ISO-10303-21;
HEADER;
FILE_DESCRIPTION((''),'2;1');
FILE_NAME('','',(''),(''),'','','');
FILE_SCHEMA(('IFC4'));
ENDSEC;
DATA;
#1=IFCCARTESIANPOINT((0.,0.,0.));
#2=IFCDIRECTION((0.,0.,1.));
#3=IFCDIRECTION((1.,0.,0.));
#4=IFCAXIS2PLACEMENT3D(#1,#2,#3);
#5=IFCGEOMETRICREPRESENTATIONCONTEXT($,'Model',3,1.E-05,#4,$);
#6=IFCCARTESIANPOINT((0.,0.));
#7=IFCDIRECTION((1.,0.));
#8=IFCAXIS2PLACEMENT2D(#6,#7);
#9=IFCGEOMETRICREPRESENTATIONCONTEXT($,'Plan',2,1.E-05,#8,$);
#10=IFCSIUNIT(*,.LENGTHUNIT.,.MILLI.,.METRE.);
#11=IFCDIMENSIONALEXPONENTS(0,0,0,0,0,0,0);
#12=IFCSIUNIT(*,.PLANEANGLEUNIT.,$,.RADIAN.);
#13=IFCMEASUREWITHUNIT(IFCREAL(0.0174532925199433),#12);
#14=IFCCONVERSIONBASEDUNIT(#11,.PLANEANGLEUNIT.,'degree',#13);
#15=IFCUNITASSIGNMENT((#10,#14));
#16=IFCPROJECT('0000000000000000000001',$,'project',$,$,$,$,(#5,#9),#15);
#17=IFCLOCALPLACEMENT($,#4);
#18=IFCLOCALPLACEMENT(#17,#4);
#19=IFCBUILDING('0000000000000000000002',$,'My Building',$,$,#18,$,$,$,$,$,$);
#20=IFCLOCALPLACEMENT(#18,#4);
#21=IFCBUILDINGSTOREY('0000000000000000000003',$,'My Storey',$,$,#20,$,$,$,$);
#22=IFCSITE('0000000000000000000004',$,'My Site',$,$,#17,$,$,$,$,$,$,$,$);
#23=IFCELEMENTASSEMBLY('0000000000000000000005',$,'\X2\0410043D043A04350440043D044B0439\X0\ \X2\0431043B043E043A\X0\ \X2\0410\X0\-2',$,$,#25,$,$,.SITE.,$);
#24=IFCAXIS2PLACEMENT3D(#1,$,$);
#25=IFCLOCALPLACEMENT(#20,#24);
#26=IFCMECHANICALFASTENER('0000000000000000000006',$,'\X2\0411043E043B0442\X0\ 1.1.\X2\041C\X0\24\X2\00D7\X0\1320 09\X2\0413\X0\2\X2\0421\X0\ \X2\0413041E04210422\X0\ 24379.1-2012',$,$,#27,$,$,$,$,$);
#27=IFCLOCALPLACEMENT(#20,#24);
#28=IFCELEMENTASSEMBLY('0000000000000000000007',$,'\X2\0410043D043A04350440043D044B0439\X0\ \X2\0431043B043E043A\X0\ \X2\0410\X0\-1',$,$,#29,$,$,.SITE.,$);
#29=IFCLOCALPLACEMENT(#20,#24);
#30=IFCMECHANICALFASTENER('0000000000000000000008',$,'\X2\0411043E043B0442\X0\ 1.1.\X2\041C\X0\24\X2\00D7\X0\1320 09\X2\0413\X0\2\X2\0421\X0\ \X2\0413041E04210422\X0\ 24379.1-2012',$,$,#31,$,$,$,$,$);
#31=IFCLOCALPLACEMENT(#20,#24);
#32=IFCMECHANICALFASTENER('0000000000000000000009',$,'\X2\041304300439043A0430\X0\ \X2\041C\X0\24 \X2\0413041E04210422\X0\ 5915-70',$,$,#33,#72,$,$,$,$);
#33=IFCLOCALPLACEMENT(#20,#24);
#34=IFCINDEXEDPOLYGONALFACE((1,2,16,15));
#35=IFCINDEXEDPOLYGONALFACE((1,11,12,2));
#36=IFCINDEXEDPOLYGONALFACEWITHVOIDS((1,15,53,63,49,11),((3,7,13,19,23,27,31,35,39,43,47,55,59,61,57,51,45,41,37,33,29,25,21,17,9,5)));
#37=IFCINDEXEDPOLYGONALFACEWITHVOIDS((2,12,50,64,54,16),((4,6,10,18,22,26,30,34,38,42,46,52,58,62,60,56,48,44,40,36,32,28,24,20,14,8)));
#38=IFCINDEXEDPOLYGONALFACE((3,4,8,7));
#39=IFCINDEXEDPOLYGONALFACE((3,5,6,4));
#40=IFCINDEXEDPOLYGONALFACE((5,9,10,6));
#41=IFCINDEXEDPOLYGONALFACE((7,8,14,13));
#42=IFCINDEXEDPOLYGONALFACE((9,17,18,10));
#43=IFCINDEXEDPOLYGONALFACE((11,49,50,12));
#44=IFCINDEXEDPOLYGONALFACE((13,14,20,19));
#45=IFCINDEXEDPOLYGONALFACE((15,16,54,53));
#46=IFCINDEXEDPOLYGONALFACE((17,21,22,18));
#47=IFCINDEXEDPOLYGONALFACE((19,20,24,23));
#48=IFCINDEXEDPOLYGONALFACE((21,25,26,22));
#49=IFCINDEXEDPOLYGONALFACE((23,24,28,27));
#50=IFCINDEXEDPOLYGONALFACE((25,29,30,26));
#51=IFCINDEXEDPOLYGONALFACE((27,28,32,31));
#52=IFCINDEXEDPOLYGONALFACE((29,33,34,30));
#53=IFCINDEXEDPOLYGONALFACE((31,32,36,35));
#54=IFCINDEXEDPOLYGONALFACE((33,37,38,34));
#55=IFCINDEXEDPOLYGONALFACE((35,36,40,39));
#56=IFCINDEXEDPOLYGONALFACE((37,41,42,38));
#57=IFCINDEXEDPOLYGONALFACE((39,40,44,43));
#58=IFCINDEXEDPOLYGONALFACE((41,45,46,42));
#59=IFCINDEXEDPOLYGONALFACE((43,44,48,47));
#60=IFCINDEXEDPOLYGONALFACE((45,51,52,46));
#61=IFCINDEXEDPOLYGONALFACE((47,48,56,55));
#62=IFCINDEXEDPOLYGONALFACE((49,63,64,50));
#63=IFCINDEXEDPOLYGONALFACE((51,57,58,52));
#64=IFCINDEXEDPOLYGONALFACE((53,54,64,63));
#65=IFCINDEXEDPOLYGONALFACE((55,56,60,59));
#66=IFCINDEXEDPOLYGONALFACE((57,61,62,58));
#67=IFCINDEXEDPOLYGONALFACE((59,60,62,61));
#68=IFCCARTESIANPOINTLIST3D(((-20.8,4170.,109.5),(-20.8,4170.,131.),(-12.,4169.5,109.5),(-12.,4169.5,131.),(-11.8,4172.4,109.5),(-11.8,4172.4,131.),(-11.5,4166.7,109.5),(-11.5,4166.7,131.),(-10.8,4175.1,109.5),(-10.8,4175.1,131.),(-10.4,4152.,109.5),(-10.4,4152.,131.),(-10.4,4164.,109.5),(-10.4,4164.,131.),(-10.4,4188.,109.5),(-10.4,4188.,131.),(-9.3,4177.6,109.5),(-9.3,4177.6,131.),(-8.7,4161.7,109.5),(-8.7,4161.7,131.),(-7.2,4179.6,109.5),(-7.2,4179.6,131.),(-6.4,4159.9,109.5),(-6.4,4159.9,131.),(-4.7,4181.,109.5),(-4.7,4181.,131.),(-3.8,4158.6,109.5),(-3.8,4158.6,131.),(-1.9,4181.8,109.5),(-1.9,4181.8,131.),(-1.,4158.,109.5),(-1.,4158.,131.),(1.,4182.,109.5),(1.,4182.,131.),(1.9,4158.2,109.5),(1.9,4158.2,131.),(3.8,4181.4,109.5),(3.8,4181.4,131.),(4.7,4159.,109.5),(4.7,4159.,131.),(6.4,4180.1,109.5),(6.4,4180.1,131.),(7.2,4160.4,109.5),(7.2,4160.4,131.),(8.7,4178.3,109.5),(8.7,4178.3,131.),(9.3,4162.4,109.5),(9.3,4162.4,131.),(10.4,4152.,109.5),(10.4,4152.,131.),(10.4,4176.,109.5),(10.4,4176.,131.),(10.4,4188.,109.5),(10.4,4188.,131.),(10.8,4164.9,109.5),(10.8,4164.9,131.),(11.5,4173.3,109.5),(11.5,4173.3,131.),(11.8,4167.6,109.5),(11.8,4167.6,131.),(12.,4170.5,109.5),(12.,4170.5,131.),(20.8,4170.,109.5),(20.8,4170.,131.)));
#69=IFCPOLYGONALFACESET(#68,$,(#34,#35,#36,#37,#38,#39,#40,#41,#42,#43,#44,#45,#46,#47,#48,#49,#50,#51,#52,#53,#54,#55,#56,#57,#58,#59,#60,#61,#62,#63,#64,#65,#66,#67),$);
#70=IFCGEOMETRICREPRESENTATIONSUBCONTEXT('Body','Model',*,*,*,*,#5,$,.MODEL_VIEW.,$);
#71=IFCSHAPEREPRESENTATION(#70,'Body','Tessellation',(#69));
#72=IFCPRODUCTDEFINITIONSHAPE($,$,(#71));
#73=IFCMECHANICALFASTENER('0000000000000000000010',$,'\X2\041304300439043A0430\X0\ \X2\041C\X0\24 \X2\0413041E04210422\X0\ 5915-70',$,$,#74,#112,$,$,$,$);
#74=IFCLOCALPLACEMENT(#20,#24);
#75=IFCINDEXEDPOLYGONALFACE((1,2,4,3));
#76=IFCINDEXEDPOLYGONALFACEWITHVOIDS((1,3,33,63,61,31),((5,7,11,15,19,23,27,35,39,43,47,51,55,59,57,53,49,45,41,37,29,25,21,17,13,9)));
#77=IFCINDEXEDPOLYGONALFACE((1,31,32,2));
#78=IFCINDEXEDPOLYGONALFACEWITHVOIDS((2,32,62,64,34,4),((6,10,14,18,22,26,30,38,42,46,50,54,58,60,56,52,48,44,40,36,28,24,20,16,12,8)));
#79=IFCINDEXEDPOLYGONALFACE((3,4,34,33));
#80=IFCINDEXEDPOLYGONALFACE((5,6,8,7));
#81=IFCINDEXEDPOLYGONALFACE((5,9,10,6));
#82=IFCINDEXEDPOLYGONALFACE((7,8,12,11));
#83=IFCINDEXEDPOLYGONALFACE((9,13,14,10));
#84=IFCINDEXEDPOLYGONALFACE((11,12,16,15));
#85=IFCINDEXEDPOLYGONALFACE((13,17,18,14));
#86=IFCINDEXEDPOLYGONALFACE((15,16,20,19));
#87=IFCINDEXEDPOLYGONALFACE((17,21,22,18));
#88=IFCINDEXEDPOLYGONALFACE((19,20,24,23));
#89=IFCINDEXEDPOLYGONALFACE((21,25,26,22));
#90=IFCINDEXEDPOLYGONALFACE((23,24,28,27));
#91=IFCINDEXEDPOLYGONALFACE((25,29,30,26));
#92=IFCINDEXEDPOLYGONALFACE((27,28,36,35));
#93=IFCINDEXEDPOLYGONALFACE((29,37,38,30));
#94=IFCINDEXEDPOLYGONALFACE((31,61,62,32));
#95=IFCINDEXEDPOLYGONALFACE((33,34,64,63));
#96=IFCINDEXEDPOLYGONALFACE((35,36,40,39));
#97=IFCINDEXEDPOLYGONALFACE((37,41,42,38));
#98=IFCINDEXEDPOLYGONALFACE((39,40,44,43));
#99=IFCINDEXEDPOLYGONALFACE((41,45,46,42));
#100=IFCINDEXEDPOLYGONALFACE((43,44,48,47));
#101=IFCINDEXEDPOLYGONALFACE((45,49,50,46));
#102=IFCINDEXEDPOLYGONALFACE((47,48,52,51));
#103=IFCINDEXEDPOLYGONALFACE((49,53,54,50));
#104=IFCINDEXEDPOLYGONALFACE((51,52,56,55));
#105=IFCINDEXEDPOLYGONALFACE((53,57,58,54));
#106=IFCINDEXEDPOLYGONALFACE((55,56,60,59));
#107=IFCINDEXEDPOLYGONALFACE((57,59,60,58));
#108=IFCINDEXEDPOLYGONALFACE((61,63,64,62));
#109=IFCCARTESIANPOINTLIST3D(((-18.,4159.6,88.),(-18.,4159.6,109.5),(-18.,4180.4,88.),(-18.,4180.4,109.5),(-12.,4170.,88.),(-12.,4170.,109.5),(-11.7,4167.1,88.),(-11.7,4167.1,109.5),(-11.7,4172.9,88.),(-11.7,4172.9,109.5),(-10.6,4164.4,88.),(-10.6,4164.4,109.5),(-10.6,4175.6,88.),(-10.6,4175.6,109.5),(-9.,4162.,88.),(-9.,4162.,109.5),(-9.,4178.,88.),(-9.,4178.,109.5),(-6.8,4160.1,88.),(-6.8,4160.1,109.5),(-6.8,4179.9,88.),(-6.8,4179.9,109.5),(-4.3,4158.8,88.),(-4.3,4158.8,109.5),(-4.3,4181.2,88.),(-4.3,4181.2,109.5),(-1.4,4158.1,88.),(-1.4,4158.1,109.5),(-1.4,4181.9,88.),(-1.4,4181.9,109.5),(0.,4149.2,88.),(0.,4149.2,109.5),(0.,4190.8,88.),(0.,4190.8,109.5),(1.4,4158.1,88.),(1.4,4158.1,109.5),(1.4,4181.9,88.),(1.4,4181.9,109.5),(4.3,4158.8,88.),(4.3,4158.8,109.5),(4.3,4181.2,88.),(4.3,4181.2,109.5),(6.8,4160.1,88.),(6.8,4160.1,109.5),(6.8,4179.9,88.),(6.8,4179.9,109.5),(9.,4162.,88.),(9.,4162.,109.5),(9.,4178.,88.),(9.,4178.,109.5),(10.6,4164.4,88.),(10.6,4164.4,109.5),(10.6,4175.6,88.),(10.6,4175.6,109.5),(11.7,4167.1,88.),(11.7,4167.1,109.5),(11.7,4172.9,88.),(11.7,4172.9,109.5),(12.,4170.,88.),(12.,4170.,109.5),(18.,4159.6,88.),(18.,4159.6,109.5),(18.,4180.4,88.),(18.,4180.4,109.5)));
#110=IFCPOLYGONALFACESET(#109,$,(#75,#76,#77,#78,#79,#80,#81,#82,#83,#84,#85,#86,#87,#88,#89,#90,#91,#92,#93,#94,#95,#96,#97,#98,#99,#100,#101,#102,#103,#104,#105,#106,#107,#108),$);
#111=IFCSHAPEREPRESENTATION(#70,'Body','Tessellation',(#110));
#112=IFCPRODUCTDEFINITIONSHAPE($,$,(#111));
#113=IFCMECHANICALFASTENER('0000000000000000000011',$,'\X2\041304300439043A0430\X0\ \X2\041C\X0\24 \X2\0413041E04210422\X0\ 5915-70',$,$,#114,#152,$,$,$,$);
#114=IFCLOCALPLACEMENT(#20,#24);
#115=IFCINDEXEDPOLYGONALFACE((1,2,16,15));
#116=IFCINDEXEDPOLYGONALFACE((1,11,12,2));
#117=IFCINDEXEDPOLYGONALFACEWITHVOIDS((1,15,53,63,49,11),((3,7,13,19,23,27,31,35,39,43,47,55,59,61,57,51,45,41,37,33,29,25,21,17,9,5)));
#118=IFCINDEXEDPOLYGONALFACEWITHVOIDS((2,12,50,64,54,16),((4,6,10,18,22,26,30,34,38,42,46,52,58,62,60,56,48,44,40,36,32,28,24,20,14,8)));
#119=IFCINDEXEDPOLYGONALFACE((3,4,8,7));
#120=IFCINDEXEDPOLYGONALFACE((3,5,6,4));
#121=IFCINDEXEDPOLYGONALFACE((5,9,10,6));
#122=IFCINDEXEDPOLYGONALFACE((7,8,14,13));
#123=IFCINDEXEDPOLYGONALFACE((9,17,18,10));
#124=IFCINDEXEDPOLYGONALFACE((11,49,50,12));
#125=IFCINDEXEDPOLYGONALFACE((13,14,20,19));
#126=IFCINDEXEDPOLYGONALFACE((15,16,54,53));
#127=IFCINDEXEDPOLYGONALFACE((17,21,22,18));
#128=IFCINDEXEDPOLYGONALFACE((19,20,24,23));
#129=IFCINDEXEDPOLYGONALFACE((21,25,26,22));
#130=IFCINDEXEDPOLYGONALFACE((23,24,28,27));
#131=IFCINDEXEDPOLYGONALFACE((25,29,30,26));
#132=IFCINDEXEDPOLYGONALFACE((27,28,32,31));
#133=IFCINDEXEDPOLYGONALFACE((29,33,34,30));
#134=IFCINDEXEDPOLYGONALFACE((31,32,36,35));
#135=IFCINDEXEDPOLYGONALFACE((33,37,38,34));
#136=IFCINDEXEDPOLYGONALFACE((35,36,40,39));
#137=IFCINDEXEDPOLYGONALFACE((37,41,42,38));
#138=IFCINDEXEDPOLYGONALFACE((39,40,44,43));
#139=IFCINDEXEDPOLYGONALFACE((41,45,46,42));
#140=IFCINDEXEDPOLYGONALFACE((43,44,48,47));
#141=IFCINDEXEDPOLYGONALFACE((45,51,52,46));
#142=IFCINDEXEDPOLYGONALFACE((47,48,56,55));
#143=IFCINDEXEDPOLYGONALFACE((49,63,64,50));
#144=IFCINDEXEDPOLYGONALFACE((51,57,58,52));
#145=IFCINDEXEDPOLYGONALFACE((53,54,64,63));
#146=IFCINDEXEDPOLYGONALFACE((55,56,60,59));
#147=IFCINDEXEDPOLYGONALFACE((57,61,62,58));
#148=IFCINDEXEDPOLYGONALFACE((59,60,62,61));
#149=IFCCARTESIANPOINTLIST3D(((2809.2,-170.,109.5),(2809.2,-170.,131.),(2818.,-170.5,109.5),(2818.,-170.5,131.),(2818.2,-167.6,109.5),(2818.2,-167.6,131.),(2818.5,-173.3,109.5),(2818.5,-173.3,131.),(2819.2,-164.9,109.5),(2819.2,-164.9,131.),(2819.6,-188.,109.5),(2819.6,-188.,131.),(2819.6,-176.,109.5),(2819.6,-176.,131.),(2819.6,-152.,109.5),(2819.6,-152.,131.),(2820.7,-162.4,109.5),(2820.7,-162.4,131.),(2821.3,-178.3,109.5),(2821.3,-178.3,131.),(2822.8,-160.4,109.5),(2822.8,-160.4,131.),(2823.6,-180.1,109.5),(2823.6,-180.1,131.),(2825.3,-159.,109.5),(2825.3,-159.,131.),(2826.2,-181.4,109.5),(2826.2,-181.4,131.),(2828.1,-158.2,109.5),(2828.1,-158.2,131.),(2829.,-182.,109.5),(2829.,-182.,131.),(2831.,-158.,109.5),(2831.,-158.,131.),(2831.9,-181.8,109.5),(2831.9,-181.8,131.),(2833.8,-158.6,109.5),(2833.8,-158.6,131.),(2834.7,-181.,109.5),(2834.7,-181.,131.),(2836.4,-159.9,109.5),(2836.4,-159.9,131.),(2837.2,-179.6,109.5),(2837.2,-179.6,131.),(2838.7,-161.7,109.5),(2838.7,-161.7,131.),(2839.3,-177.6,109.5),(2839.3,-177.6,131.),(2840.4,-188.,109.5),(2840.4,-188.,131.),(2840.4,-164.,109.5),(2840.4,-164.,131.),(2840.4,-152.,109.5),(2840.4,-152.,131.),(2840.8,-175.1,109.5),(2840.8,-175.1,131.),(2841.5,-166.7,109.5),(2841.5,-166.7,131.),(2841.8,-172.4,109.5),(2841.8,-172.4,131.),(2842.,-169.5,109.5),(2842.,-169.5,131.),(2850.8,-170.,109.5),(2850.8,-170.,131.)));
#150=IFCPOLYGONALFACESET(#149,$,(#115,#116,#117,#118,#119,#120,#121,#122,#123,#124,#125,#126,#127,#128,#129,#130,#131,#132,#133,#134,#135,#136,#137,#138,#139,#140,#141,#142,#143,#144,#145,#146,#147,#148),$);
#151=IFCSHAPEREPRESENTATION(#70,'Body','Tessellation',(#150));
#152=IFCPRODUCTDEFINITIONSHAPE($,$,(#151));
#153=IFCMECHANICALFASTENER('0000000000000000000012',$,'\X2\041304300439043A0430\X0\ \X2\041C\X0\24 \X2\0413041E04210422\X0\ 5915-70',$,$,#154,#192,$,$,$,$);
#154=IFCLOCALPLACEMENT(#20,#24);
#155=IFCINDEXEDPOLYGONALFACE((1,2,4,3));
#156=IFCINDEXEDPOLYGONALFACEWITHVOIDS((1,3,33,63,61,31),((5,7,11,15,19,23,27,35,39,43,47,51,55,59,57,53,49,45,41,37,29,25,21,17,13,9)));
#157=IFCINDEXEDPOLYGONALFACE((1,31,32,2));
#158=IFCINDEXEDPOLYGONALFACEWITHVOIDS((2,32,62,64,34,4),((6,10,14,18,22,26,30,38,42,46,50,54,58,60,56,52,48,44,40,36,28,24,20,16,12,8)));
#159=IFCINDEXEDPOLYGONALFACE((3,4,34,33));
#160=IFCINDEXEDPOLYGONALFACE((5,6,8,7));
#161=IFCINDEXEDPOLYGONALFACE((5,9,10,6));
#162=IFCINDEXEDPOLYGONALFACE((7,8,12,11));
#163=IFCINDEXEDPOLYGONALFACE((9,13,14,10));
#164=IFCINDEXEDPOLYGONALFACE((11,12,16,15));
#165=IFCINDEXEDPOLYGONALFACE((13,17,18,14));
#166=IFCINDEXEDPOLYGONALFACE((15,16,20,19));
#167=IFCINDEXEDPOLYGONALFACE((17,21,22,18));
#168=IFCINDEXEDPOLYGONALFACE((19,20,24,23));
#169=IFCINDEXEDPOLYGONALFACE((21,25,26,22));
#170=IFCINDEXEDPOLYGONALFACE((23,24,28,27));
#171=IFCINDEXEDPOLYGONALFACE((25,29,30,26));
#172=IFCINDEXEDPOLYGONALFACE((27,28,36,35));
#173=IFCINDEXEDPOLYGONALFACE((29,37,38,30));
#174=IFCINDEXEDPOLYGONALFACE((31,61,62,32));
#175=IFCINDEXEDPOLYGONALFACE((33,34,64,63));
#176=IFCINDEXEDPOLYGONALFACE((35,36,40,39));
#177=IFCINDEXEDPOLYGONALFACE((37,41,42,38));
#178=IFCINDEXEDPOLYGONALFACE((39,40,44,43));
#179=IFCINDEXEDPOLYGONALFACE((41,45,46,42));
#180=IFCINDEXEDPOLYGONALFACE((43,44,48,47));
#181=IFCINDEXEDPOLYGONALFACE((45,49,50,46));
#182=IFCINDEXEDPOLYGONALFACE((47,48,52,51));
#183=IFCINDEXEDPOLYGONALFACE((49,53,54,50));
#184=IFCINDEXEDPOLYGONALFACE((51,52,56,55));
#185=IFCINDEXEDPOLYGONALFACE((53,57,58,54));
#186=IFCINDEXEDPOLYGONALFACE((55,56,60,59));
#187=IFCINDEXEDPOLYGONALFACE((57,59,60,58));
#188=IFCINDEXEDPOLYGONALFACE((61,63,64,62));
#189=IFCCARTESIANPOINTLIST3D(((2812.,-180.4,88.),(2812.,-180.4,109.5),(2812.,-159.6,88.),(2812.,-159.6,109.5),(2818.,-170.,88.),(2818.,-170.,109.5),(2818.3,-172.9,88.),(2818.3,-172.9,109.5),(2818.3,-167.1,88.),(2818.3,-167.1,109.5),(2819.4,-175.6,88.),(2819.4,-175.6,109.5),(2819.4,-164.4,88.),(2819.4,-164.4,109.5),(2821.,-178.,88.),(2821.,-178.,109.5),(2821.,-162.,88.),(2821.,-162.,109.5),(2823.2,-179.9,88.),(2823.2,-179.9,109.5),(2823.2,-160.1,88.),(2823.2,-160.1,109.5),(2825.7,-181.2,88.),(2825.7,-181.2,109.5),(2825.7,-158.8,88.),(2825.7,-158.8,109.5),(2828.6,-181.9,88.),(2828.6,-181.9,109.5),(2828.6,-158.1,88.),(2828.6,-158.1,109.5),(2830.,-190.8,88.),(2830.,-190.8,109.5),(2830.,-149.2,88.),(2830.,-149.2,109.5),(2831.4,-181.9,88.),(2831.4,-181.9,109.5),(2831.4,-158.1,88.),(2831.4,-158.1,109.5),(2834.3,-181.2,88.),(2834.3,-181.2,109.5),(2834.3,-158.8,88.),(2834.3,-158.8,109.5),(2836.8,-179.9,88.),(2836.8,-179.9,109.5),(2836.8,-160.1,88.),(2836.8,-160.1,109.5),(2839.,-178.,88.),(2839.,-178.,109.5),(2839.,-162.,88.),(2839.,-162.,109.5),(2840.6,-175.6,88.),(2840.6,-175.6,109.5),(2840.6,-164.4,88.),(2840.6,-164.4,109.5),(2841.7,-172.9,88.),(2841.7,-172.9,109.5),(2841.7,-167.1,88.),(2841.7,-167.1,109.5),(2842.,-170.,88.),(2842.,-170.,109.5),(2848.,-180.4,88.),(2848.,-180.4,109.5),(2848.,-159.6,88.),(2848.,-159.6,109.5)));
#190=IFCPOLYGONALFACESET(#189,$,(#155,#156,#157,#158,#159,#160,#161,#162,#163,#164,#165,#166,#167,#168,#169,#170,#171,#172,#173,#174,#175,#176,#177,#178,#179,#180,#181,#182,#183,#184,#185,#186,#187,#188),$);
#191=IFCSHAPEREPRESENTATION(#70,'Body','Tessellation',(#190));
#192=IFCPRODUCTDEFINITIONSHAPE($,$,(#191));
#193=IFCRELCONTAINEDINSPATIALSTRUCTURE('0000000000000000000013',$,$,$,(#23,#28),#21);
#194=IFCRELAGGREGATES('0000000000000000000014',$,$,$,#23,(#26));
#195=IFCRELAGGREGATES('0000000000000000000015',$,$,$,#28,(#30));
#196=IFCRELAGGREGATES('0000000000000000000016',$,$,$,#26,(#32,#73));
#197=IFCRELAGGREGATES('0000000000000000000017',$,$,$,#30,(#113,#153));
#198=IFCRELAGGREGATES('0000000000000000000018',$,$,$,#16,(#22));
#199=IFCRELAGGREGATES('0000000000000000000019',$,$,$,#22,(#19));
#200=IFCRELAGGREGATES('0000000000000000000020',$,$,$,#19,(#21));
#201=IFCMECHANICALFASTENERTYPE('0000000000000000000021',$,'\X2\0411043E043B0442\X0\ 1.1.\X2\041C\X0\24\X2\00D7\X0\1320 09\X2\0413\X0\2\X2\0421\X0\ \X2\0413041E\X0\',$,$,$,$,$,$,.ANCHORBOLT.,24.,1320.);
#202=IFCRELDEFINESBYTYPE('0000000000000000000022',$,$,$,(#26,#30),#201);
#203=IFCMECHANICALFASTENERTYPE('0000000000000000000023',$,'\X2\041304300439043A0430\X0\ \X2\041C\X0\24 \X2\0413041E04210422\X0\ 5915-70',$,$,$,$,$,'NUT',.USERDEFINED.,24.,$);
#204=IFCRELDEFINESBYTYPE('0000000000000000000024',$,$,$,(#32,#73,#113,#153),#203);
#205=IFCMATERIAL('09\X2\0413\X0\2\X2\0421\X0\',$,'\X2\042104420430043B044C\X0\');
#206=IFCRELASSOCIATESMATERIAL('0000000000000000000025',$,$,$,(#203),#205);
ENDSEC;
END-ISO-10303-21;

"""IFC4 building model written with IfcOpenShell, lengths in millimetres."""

from ifc_helpers import new_model, entity, si_unit, converted_unit, frame, origin_with_axes, origin_2d_with_axis, place, context, subcontext, project, spatial, polyline, outline, extrude, source, transform, mapped, material, type_object, type_shapes, element, aggregate, save


model = new_model("IFC4")

# Units and contexts
model_context = context("Model", 3, precision=1e-05, world=origin_with_axes())
plan_context = context("Plan", 2, precision=1e-05, world=origin_2d_with_axis())
body_context = subcontext(model_context, "Body", "Model", "MODEL_VIEW")
ifc_project = project(units=[si_unit("LENGTHUNIT", "METRE", prefix="MILLI"), converted_unit("PLANEANGLEUNIT", "degree", entity("IfcReal", 0.0174532925199433), si_unit("PLANEANGLEUNIT", "RADIAN"), dimensions=[0, 0, 0, 0, 0, 0, 0])], contexts=[model_context, plan_context])

# Site, building, storey
site_placement = place(None, origin_with_axes())
site = spatial("IfcSite", under=ifc_project, at=site_placement, Name="My Site")
building_placement = place(site_placement, origin_with_axes())
building = spatial("IfcBuilding", under=site, at=building_placement, Name="My Building")
storey_placement = place(building_placement, origin_with_axes())
storey = spatial("IfcBuildingStorey", under=building, at=storey_placement, Name="My Storey")

# Element assemblies, mechanical fasteners
ifc_material_1 = material(Name="09Г2С", Category="Сталь")
mechanical_fastener_type_1 = type_object("IfcMechanicalFastenerType", Name="Болт 1.1.М24×1320 09Г2С ГО", NominalDiameter=24.0, NominalLength=1320.0, PredefinedType="ANCHORBOLT")
assembly_1_placement = place(storey_placement, frame((0.0, 4000.0, 0.0), z_axis=(0.0, 0.0, 1.0), x_axis=(1.0, 0.0, 0.0)))
assembly_1 = element("IfcElementAssembly", 1, at=assembly_1_placement, inside=storey, Name="Анкерный блок А-2", AssemblyPlace="SITE")
mechanical_fastener_1_placement = place(assembly_1_placement, frame((0.0, 170.0, 0.0), z_axis=(0.0, 0.0, 1.0), x_axis=(-1.0, 0.0, 0.0)))
mechanical_fastener_1 = element("IfcMechanicalFastener", 2, at=mechanical_fastener_1_placement, type_object=mechanical_fastener_type_1, Name="Болт 1.1.М24×1320 09Г2С ГОСТ 24379.1-2012")
aggregate(assembly_1, [mechanical_fastener_1])
assembly_2_placement = place(storey_placement, frame((3000.0, 0.0, 0.0), z_axis=(0.0, 0.0, 1.0), x_axis=(1.0, 0.0, 0.0)))
assembly_2 = element("IfcElementAssembly", 3, at=assembly_2_placement, inside=storey, Name="Анкерный блок А-1", AssemblyPlace="SITE")
mechanical_fastener_2_placement = place(assembly_2_placement, frame((-170.0, -170.0, 0.0), z_axis=(0.0, 0.0, 1.0), x_axis=(1.0, 0.0, 0.0)))
mechanical_fastener_2 = element("IfcMechanicalFastener", 4, at=mechanical_fastener_2_placement, type_object=mechanical_fastener_type_1, Name="Болт 1.1.М24×1320 09Г2С ГОСТ 24379.1-2012")
aggregate(assembly_2, [mechanical_fastener_2])

# Mechanical fasteners
mechanical_fastener_type_2 = type_object("IfcMechanicalFastenerType", Name="Гайка М24 ГОСТ 5915-70", ElementType="NUT", NominalDiameter=24.0, PredefinedType="USERDEFINED", material=ifc_material_1)
shared_shape_1 = source(origin_with_axes(), body_context, "Body", "SweptSolid", [
    extrude(outline(polyline([(-10.4, -18.0), (10.4, -18.0), (20.8, 0.0), (10.4, 18.0), (-10.4, 18.0), (-20.8, 0.0), (-10.4, -18.0)]), holes=[polyline([(-8.0, 9.0), (-5.6, 10.6), (-2.9, 11.7), (0.0, 12.0), (2.9, 11.7), (5.6, 10.6), (8.0, 9.0), (9.9, 6.8), (11.2, 4.3), (11.9, 1.4), (11.9, -1.4), (11.2, -4.3), (9.9, -6.8), (8.0, -9.0), (5.6, -10.6), (2.9, -11.7), (0.0, -12.0), (-2.9, -11.7), (-5.6, -10.6), (-8.0, -9.0), (-9.9, -6.8), (-11.2, -4.3), (-11.9, -1.4), (-11.9, 1.4), (-11.2, 4.3), (-9.9, 6.8), (-8.0, 9.0)])]), frame((0.0, 0.0, 0.0), z_axis=(0.0, 0.0, 1.0), x_axis=(0.0, 1.0, 0.0)), (0.0, 0.0, 1.0), 21.5),
])
type_shapes(mechanical_fastener_type_2, [shared_shape_1])
mechanical_fastener_3_placement = place(mechanical_fastener_1_placement, frame((0.0, 0.0, 109.5), z_axis=(0.0, 0.0, 1.0), x_axis=(0.866025, 0.5, 0.0)))
mechanical_fastener_3 = element("IfcMechanicalFastener", 5, at=mechanical_fastener_3_placement, type_object=mechanical_fastener_type_2, Name="Гайка М24 ГОСТ 5915-70", context=body_context, shape_type="MappedRepresentation", body=[
    mapped(shared_shape_1, transform((0.0, 0.0, 0.0), x_axis=(1.0, 0.0, 0.0), y_axis=(0.0, 1.0, 0.0), z_axis=(0.0, 0.0, 1.0), scale=1.0)),
])
mechanical_fastener_4_placement = place(mechanical_fastener_1_placement, frame((0.0, 0.0, 88.0), z_axis=(0.0, 0.0, 1.0), x_axis=(1.0, 0.0, 0.0)))
mechanical_fastener_4 = element("IfcMechanicalFastener", 6, at=mechanical_fastener_4_placement, type_object=mechanical_fastener_type_2, Name="Гайка М24 ГОСТ 5915-70", context=body_context, shape_type="MappedRepresentation", body=[
    mapped(shared_shape_1, transform((0.0, 0.0, 0.0), x_axis=(1.0, 0.0, 0.0), y_axis=(0.0, 1.0, 0.0), z_axis=(0.0, 0.0, 1.0), scale=1.0)),
])
mechanical_fastener_5_placement = place(mechanical_fastener_2_placement, frame((0.0, 0.0, 109.5), z_axis=(0.0, 0.0, 1.0), x_axis=(0.866025, 0.5, 0.0)))
mechanical_fastener_5 = element("IfcMechanicalFastener", 7, at=mechanical_fastener_5_placement, type_object=mechanical_fastener_type_2, Name="Гайка М24 ГОСТ 5915-70", context=body_context, shape_type="MappedRepresentation", body=[
    mapped(shared_shape_1, transform((0.0, 0.0, 0.0), x_axis=(1.0, 0.0, 0.0), y_axis=(0.0, 1.0, 0.0), z_axis=(0.0, 0.0, 1.0), scale=1.0)),
])
mechanical_fastener_6_placement = place(mechanical_fastener_2_placement, frame((0.0, 0.0, 88.0), z_axis=(0.0, 0.0, 1.0), x_axis=(1.0, 0.0, 0.0)))
mechanical_fastener_6 = element("IfcMechanicalFastener", 8, at=mechanical_fastener_6_placement, type_object=mechanical_fastener_type_2, Name="Гайка М24 ГОСТ 5915-70", context=body_context, shape_type="MappedRepresentation", body=[
    mapped(shared_shape_1, transform((0.0, 0.0, 0.0), x_axis=(1.0, 0.0, 0.0), y_axis=(0.0, 1.0, 0.0), z_axis=(0.0, 0.0, 1.0), scale=1.0)),
])
aggregate(mechanical_fastener_1, [mechanical_fastener_3, mechanical_fastener_4])
aggregate(mechanical_fastener_2, [mechanical_fastener_5, mechanical_fastener_6])

save(model, "model.ifc")
